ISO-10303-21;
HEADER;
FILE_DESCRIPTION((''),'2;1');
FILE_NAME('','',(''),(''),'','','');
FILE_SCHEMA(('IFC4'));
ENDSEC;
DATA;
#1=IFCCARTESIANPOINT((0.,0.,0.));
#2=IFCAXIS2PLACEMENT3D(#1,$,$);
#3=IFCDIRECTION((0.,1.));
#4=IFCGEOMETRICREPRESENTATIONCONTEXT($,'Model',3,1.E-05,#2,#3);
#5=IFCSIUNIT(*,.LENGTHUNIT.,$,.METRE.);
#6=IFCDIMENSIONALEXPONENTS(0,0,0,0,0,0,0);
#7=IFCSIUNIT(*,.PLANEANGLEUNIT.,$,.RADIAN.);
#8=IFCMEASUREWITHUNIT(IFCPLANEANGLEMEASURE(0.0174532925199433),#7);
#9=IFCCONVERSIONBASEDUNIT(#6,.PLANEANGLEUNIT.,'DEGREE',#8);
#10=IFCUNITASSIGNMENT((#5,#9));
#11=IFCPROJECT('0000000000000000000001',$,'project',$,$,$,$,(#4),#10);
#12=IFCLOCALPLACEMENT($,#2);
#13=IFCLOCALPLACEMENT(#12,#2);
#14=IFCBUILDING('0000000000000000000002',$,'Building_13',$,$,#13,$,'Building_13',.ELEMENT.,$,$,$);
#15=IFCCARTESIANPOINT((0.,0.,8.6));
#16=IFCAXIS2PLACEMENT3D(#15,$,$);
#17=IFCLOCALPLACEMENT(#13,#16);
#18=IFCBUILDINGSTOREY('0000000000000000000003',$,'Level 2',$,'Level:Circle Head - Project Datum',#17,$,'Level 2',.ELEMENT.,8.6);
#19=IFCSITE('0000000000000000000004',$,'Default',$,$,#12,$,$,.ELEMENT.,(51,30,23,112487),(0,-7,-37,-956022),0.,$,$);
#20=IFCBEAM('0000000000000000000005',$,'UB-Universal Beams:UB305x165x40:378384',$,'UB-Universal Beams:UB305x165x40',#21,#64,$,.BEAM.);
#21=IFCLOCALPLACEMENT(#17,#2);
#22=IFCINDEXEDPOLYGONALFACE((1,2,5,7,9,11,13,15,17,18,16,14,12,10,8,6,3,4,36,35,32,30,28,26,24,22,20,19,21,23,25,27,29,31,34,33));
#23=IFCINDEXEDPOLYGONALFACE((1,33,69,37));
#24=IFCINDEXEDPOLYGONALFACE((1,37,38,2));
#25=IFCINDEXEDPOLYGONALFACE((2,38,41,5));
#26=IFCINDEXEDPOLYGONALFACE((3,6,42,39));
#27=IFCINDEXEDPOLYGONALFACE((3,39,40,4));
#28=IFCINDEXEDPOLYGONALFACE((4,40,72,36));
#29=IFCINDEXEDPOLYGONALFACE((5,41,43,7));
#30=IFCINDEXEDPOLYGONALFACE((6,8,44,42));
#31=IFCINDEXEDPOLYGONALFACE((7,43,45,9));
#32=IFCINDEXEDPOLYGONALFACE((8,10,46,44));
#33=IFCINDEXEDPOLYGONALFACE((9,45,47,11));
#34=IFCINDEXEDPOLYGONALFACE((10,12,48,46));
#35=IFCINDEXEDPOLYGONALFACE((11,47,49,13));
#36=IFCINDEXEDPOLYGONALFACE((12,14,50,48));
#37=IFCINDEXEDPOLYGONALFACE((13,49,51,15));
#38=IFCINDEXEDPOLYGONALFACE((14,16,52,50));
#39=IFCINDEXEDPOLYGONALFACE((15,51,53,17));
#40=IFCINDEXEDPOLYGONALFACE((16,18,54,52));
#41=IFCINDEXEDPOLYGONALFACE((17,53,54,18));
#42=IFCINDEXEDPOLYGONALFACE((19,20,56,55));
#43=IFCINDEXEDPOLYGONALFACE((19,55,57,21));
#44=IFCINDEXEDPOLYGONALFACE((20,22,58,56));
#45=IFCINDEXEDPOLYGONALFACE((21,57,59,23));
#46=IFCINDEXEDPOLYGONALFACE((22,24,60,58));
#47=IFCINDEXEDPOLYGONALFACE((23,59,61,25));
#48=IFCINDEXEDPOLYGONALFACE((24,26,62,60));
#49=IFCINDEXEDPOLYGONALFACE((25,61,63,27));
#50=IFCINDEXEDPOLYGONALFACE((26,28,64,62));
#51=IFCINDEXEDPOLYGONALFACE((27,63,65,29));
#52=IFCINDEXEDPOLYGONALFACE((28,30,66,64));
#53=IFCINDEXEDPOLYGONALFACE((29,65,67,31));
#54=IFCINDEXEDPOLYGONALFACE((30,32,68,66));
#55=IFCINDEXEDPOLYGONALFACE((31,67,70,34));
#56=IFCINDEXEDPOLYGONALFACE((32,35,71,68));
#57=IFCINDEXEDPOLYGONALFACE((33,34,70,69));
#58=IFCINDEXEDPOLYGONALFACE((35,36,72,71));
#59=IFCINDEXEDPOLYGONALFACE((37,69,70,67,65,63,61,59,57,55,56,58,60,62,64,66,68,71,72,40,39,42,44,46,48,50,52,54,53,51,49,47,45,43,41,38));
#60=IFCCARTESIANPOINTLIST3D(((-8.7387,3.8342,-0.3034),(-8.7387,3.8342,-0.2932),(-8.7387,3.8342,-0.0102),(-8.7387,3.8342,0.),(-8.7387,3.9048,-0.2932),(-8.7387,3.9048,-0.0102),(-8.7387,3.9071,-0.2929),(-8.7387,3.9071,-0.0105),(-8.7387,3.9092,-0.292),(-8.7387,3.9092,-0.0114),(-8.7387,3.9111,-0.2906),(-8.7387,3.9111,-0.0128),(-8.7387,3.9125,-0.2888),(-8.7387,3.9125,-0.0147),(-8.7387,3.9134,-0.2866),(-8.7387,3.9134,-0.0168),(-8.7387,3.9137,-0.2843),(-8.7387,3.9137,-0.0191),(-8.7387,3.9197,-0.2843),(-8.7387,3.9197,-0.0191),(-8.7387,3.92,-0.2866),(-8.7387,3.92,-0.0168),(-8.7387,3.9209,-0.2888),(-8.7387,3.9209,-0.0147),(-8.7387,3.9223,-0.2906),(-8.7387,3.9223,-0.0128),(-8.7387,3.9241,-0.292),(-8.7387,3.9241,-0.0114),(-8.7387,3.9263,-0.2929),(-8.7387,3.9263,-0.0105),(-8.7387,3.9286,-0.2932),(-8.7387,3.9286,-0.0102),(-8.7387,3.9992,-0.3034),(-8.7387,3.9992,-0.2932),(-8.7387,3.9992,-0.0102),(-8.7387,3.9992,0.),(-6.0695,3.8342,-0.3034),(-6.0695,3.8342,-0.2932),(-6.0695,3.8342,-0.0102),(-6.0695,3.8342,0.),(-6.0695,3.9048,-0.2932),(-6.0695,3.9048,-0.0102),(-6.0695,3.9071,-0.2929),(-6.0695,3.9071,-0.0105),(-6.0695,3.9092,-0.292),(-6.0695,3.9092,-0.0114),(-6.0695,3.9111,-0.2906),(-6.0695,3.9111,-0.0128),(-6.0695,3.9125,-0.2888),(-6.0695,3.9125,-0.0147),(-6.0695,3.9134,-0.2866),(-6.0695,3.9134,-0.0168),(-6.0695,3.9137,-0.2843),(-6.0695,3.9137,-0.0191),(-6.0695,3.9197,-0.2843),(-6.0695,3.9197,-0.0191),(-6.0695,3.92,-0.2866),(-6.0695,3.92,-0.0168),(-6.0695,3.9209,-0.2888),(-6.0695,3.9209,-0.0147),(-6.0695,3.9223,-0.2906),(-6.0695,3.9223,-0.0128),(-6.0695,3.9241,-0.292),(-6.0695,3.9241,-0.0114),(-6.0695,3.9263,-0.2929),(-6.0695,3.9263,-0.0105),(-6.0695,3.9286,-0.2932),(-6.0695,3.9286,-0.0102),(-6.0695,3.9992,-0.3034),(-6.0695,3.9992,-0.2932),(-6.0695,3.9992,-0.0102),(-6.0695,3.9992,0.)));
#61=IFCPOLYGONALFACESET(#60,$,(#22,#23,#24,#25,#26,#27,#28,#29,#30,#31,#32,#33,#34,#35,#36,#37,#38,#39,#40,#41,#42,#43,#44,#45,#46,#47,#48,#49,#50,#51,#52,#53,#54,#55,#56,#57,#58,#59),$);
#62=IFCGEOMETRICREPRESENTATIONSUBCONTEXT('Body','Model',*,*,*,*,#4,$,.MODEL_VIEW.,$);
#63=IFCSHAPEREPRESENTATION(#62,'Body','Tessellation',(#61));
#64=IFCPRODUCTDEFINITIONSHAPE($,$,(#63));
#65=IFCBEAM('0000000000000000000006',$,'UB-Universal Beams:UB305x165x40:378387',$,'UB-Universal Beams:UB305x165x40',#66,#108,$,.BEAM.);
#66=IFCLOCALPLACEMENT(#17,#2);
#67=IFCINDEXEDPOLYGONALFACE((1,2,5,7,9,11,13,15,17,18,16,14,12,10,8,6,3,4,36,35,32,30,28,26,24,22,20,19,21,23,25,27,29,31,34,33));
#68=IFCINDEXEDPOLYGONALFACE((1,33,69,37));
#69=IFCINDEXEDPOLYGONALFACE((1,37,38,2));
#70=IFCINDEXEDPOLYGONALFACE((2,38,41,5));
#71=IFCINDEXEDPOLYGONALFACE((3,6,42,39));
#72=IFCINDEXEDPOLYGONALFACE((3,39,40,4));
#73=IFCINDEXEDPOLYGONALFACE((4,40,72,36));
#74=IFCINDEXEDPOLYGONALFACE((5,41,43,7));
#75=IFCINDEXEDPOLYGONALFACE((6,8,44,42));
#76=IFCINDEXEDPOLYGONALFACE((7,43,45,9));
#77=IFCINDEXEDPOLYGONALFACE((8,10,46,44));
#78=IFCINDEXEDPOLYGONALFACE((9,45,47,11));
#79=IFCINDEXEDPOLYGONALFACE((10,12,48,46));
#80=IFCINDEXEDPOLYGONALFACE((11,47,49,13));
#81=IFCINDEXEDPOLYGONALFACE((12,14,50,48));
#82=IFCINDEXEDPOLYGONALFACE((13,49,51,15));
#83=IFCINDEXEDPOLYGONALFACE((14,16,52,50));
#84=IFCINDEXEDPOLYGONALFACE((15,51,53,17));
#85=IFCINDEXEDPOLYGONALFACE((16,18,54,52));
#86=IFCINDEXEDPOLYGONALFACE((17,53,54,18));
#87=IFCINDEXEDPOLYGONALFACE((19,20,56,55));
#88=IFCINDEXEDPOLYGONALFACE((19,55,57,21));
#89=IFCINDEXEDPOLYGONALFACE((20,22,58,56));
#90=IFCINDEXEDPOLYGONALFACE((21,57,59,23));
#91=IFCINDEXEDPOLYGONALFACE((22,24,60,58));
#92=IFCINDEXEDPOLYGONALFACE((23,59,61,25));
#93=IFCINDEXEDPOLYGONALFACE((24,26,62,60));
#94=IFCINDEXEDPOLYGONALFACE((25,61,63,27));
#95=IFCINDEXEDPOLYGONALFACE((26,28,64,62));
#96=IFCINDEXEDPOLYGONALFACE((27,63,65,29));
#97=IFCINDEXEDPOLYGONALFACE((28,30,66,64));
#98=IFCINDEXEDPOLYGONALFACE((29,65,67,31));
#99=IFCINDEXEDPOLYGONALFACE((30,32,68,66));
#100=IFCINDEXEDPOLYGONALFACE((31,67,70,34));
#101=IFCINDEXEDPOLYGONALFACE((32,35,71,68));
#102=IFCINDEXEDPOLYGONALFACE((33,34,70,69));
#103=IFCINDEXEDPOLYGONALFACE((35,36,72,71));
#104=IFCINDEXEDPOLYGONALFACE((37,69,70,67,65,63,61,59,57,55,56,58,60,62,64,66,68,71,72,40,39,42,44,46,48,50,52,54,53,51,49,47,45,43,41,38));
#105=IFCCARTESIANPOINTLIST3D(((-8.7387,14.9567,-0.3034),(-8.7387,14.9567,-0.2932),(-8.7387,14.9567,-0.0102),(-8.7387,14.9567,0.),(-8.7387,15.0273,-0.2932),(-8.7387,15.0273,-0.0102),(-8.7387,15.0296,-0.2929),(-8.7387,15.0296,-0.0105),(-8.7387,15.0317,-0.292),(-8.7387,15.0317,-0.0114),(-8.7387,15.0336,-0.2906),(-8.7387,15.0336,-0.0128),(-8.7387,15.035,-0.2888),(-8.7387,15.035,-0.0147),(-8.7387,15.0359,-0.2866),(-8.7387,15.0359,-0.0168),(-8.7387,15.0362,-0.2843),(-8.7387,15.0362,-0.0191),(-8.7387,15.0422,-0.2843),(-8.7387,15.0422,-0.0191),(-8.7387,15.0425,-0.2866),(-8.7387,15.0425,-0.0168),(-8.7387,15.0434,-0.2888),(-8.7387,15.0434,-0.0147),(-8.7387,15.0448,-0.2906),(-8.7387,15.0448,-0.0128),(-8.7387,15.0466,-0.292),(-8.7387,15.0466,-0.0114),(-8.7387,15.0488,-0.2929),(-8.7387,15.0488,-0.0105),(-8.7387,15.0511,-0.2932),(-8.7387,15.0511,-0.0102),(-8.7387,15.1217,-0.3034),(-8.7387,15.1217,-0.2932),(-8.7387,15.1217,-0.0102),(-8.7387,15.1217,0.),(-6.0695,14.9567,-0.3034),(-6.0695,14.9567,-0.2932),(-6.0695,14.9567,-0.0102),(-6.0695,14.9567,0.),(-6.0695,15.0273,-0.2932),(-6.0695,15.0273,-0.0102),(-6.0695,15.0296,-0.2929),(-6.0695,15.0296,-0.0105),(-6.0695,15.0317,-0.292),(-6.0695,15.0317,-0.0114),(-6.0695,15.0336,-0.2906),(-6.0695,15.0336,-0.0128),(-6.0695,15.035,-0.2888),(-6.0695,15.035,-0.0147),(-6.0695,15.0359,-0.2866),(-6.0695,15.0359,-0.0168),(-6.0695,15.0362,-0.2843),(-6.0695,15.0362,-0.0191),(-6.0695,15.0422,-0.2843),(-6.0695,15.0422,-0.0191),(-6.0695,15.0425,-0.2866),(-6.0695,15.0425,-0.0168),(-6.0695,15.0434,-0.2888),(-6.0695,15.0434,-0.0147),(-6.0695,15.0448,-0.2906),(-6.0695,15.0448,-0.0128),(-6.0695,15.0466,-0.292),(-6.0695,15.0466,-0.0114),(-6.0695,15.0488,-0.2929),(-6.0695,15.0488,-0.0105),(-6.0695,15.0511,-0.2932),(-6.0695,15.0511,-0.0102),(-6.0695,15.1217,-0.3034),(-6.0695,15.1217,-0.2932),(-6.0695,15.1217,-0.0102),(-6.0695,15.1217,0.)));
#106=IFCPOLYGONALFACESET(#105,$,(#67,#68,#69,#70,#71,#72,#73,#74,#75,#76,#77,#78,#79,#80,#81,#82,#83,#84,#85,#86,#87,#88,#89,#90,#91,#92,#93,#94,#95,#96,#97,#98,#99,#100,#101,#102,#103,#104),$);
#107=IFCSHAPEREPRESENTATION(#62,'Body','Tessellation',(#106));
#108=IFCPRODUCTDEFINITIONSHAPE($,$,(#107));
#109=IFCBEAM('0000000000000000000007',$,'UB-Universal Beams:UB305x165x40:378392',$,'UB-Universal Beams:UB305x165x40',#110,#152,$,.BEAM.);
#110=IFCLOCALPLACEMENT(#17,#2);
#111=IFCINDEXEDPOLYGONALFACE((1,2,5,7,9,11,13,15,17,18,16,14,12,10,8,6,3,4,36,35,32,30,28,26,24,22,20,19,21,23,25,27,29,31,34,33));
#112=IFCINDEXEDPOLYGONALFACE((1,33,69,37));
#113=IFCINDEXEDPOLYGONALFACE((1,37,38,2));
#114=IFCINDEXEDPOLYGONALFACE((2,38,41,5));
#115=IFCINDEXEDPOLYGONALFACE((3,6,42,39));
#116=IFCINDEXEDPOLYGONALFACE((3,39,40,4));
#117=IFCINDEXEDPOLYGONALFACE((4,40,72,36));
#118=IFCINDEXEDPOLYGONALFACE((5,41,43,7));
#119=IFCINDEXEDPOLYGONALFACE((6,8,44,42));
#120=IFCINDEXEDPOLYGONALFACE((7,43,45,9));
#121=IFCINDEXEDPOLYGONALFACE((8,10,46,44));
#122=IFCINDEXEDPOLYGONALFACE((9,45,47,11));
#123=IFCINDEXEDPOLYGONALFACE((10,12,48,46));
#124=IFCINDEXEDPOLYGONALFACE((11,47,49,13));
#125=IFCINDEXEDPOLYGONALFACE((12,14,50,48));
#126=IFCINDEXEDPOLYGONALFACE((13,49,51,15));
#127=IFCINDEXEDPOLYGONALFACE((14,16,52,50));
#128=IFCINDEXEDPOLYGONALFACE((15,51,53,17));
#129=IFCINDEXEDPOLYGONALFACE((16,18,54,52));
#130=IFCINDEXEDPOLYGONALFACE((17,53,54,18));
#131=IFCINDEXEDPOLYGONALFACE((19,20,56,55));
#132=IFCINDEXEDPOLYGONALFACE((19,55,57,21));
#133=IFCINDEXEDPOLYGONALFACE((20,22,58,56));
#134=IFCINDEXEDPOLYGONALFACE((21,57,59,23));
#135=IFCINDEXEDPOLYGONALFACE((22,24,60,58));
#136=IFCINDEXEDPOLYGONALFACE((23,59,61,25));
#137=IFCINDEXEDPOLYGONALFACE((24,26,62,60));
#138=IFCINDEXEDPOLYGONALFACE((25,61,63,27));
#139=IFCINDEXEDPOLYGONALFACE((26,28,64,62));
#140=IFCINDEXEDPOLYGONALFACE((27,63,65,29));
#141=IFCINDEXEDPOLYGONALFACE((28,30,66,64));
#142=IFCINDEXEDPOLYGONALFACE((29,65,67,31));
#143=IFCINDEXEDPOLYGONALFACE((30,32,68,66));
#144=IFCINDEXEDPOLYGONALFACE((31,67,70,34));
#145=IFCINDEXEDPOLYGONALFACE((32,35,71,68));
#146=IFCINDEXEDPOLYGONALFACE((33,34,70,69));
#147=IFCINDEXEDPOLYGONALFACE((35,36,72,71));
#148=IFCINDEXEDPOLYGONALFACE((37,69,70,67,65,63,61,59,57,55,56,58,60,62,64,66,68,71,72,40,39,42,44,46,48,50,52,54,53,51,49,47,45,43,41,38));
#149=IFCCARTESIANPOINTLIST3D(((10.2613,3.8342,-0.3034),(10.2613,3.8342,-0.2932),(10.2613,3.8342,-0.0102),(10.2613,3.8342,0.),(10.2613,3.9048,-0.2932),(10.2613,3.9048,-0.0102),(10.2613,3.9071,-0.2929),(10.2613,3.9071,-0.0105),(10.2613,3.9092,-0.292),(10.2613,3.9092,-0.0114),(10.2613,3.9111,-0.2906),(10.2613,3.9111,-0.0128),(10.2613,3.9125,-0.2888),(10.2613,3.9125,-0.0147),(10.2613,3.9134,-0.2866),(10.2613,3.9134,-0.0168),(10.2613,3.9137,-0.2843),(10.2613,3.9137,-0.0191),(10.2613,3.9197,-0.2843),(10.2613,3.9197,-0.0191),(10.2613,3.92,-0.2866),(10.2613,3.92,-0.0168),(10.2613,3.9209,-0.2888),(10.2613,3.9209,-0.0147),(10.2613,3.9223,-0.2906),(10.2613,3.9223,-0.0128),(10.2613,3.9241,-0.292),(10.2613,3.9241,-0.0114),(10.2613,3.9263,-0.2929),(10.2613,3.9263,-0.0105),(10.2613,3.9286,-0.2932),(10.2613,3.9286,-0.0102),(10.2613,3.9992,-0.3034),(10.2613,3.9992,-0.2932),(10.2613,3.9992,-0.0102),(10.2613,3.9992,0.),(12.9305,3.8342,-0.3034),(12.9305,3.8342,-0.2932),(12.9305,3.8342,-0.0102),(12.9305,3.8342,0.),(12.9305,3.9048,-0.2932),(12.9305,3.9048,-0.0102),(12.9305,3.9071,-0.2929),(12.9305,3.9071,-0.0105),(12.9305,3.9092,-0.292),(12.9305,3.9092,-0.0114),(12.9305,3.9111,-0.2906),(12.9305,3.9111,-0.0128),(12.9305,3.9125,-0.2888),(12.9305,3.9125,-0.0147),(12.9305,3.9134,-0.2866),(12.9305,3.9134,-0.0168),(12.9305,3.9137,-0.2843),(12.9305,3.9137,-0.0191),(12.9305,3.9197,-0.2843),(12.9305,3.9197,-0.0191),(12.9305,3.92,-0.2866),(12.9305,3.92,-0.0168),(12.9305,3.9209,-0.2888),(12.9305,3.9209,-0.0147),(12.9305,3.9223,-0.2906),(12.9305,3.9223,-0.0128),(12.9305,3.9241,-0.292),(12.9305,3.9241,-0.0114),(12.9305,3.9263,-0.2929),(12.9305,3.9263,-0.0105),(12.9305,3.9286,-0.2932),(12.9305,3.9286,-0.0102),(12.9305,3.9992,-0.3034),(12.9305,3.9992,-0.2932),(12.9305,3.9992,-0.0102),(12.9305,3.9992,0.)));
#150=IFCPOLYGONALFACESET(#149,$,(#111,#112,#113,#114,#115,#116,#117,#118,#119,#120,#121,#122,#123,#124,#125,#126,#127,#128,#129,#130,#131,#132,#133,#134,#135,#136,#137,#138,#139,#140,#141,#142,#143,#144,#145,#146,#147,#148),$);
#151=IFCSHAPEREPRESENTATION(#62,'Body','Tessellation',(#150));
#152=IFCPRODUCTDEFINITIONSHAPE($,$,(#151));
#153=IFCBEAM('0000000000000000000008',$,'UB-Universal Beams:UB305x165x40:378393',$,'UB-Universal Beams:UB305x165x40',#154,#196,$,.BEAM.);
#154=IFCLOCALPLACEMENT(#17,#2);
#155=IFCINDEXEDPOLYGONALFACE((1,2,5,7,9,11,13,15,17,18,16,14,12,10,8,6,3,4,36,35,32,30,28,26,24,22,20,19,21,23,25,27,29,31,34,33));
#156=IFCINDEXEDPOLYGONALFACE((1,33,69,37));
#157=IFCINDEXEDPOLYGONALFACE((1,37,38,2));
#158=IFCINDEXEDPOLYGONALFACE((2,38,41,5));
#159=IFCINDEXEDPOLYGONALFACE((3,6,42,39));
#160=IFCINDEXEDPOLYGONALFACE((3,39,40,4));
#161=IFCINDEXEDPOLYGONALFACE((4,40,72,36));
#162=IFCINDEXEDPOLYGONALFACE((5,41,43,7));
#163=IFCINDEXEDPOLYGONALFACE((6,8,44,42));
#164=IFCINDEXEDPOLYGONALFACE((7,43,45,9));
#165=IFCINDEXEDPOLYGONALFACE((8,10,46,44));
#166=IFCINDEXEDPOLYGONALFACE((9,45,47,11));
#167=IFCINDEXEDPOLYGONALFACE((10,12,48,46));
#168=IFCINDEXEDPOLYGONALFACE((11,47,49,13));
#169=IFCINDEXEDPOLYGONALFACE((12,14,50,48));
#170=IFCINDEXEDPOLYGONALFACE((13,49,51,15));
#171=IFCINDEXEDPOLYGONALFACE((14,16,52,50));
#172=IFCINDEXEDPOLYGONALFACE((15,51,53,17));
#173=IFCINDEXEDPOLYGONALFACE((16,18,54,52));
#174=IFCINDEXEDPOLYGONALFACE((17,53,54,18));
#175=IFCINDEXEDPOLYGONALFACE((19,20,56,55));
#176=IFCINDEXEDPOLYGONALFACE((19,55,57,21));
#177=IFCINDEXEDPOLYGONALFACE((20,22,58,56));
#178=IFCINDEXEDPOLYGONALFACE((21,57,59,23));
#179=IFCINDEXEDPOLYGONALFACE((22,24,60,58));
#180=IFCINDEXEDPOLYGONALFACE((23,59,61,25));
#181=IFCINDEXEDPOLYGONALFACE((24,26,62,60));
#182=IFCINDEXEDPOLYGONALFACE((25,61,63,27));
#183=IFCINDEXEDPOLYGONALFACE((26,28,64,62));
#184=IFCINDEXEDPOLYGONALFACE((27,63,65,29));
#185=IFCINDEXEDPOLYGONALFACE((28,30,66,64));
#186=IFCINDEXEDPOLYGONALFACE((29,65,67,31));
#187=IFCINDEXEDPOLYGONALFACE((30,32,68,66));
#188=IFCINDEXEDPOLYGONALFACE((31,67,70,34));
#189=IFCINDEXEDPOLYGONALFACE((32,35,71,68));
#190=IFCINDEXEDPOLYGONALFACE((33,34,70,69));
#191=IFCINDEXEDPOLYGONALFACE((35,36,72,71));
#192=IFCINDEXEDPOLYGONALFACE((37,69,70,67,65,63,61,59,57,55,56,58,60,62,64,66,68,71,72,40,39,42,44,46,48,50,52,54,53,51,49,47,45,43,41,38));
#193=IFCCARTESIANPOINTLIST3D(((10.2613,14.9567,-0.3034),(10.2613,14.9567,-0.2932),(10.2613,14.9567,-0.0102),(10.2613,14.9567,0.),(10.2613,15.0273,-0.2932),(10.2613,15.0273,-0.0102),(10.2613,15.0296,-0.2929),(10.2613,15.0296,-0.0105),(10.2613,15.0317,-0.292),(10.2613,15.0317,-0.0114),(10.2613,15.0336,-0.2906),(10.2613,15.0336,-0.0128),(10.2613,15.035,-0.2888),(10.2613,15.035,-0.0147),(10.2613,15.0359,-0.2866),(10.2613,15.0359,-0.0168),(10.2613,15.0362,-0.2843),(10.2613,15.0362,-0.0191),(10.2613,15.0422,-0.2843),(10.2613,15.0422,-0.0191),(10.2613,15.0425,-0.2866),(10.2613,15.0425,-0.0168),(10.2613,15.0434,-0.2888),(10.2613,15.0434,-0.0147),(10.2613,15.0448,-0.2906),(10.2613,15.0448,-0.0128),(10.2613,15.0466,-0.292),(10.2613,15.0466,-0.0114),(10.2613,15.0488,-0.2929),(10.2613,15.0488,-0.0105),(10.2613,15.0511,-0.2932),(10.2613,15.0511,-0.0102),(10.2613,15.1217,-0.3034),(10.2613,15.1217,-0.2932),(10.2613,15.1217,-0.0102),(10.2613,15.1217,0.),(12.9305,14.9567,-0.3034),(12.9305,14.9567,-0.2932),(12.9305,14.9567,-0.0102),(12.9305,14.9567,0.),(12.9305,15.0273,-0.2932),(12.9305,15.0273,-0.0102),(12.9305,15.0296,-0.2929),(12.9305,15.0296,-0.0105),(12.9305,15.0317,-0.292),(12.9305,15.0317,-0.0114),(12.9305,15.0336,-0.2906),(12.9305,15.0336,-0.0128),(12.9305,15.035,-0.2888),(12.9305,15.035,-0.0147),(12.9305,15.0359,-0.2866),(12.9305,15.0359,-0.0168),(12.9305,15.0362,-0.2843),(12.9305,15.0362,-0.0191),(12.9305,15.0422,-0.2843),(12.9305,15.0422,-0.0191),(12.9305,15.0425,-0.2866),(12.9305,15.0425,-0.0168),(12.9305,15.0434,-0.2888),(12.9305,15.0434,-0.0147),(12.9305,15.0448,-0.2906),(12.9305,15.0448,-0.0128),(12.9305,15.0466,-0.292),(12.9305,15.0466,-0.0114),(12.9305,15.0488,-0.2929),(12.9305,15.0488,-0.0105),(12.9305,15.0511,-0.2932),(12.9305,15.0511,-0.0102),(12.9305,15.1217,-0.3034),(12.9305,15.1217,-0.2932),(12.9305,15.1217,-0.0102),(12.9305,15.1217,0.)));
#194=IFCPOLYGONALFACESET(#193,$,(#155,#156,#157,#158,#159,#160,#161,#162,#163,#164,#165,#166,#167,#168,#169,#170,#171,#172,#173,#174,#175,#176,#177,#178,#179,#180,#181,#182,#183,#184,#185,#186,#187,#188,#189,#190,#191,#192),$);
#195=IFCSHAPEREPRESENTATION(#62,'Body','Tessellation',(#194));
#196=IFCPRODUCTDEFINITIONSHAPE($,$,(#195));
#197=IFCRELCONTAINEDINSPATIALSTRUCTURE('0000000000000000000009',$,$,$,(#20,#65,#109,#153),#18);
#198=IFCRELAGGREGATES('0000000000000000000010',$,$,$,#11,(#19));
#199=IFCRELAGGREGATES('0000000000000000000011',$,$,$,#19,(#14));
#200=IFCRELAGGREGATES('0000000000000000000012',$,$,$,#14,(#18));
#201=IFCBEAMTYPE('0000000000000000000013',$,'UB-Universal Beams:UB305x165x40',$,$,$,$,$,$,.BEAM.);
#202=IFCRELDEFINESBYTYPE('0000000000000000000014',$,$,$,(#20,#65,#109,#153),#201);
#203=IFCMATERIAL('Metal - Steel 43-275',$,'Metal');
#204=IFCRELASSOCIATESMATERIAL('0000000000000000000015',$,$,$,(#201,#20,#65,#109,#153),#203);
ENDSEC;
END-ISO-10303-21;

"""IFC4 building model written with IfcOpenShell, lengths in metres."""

from ifc_helpers import new_model, entity, si_unit, converted_unit, direction, frame, origin, place, context, subcontext, project, spatial, line, arc, indexed_curve, outline, extrude, source, transform, mapped, material, type_object, type_shapes, element, save


model = new_model("IFC4")

# Units and contexts
model_context = context("Model", 3, precision=1e-05, world=origin(), true_north=direction((0.0, 1.0)))
body_context = subcontext(model_context, "Body", "Model", "MODEL_VIEW")
ifc_project = project(units=[si_unit("LENGTHUNIT", "METRE"), converted_unit("PLANEANGLEUNIT", "DEGREE", entity("IfcPlaneAngleMeasure", 0.0174532925199433), si_unit("PLANEANGLEUNIT", "RADIAN"), dimensions=[0, 0, 0, 0, 0, 0, 0])], contexts=[model_context])

# Site, building, storey
site_placement = place(None, origin())
site = spatial("IfcSite", under=ifc_project, at=site_placement, Name="Default", CompositionType="ELEMENT", RefLatitude=(51, 30, 23, 112487), RefLongitude=(0, -7, -37, -956022), RefElevation=0.0)
building_placement = place(site_placement, origin())
building = spatial("IfcBuilding", under=site, at=building_placement, Name="Building_13", LongName="Building_13", CompositionType="ELEMENT")
storey_placement = place(building_placement, frame((0.0, 0.0, 8.6)))
storey = spatial("IfcBuildingStorey", under=building, at=storey_placement, Name="Level 2", ObjectType="Level:Circle Head - Project Datum", LongName="Level 2", CompositionType="ELEMENT", Elevation=8.6)

# Beams
ifc_material_1 = material(Name="Metal - Steel 43-275", Category="Metal")
beam_type_1 = type_object("IfcBeamType", Name="UB-Universal Beams:UB305x165x40", PredefinedType="BEAM", material=ifc_material_1)
shared_shape_1 = source(origin(), body_context, "Body", "SweptSolid", [
    extrude(outline(indexed_curve([(-0.0825, -0.1415), (-0.0825, -0.1517), (0.0825, -0.1517), (0.0825, -0.1415), (0.0119, -0.1415), (0.0056, -0.1389), (0.003, -0.1326), (0.003, 0.1326), (0.0056, 0.1389), (0.0119, 0.1415), (0.0825, 0.1415), (0.0825, 0.1517), (-0.0825, 0.1517), (-0.0825, 0.1415), (-0.0119, 0.1415), (-0.0056, 0.1389), (-0.003, 0.1326), (-0.003, -0.1326), (-0.0056, -0.1389), (-0.0119, -0.1415)], segments=[line(1, 2, 3, 4, 5), arc(5, 6, 7), line(7, 8), arc(8, 9, 10), line(10, 11, 12, 13, 14, 15), arc(15, 16, 17), line(17, 18), arc(18, 19, 20), line(20, 1)], self_intersect=False)), frame((-1.3346, 0.0, 0.0), z_axis=(-1.0, 0.0, 0.0), x_axis=(0.0, -1.0, 0.0)), (0.0, 0.0, -1.0), 2.6692),
])
type_shapes(beam_type_1, [shared_shape_1])
for number, where, name in (
    (1, (-7.4041, 3.9167, -0.1517), "UB-Universal Beams:UB305x165x40:378384"),
    (2, (-7.4041, 15.0392, -0.1517), "UB-Universal Beams:UB305x165x40:378387"),
    (3, (11.5959, 3.9167, -0.1517), "UB-Universal Beams:UB305x165x40:378392"),
    (4, (11.5959, 15.0392, -0.1517), "UB-Universal Beams:UB305x165x40:378393"),
):
    element("IfcBeam", number, at=place(storey_placement, frame(where)), inside=storey, type_object=beam_type_1, material=ifc_material_1, Name=name, ObjectType="UB-Universal Beams:UB305x165x40", PredefinedType="BEAM", context=body_context, shape_type="MappedRepresentation", body=[
        mapped(shared_shape_1, transform((0.0, 0.0, 0.0), scale=1.0)),
    ])

save(model, "model.ifc")
